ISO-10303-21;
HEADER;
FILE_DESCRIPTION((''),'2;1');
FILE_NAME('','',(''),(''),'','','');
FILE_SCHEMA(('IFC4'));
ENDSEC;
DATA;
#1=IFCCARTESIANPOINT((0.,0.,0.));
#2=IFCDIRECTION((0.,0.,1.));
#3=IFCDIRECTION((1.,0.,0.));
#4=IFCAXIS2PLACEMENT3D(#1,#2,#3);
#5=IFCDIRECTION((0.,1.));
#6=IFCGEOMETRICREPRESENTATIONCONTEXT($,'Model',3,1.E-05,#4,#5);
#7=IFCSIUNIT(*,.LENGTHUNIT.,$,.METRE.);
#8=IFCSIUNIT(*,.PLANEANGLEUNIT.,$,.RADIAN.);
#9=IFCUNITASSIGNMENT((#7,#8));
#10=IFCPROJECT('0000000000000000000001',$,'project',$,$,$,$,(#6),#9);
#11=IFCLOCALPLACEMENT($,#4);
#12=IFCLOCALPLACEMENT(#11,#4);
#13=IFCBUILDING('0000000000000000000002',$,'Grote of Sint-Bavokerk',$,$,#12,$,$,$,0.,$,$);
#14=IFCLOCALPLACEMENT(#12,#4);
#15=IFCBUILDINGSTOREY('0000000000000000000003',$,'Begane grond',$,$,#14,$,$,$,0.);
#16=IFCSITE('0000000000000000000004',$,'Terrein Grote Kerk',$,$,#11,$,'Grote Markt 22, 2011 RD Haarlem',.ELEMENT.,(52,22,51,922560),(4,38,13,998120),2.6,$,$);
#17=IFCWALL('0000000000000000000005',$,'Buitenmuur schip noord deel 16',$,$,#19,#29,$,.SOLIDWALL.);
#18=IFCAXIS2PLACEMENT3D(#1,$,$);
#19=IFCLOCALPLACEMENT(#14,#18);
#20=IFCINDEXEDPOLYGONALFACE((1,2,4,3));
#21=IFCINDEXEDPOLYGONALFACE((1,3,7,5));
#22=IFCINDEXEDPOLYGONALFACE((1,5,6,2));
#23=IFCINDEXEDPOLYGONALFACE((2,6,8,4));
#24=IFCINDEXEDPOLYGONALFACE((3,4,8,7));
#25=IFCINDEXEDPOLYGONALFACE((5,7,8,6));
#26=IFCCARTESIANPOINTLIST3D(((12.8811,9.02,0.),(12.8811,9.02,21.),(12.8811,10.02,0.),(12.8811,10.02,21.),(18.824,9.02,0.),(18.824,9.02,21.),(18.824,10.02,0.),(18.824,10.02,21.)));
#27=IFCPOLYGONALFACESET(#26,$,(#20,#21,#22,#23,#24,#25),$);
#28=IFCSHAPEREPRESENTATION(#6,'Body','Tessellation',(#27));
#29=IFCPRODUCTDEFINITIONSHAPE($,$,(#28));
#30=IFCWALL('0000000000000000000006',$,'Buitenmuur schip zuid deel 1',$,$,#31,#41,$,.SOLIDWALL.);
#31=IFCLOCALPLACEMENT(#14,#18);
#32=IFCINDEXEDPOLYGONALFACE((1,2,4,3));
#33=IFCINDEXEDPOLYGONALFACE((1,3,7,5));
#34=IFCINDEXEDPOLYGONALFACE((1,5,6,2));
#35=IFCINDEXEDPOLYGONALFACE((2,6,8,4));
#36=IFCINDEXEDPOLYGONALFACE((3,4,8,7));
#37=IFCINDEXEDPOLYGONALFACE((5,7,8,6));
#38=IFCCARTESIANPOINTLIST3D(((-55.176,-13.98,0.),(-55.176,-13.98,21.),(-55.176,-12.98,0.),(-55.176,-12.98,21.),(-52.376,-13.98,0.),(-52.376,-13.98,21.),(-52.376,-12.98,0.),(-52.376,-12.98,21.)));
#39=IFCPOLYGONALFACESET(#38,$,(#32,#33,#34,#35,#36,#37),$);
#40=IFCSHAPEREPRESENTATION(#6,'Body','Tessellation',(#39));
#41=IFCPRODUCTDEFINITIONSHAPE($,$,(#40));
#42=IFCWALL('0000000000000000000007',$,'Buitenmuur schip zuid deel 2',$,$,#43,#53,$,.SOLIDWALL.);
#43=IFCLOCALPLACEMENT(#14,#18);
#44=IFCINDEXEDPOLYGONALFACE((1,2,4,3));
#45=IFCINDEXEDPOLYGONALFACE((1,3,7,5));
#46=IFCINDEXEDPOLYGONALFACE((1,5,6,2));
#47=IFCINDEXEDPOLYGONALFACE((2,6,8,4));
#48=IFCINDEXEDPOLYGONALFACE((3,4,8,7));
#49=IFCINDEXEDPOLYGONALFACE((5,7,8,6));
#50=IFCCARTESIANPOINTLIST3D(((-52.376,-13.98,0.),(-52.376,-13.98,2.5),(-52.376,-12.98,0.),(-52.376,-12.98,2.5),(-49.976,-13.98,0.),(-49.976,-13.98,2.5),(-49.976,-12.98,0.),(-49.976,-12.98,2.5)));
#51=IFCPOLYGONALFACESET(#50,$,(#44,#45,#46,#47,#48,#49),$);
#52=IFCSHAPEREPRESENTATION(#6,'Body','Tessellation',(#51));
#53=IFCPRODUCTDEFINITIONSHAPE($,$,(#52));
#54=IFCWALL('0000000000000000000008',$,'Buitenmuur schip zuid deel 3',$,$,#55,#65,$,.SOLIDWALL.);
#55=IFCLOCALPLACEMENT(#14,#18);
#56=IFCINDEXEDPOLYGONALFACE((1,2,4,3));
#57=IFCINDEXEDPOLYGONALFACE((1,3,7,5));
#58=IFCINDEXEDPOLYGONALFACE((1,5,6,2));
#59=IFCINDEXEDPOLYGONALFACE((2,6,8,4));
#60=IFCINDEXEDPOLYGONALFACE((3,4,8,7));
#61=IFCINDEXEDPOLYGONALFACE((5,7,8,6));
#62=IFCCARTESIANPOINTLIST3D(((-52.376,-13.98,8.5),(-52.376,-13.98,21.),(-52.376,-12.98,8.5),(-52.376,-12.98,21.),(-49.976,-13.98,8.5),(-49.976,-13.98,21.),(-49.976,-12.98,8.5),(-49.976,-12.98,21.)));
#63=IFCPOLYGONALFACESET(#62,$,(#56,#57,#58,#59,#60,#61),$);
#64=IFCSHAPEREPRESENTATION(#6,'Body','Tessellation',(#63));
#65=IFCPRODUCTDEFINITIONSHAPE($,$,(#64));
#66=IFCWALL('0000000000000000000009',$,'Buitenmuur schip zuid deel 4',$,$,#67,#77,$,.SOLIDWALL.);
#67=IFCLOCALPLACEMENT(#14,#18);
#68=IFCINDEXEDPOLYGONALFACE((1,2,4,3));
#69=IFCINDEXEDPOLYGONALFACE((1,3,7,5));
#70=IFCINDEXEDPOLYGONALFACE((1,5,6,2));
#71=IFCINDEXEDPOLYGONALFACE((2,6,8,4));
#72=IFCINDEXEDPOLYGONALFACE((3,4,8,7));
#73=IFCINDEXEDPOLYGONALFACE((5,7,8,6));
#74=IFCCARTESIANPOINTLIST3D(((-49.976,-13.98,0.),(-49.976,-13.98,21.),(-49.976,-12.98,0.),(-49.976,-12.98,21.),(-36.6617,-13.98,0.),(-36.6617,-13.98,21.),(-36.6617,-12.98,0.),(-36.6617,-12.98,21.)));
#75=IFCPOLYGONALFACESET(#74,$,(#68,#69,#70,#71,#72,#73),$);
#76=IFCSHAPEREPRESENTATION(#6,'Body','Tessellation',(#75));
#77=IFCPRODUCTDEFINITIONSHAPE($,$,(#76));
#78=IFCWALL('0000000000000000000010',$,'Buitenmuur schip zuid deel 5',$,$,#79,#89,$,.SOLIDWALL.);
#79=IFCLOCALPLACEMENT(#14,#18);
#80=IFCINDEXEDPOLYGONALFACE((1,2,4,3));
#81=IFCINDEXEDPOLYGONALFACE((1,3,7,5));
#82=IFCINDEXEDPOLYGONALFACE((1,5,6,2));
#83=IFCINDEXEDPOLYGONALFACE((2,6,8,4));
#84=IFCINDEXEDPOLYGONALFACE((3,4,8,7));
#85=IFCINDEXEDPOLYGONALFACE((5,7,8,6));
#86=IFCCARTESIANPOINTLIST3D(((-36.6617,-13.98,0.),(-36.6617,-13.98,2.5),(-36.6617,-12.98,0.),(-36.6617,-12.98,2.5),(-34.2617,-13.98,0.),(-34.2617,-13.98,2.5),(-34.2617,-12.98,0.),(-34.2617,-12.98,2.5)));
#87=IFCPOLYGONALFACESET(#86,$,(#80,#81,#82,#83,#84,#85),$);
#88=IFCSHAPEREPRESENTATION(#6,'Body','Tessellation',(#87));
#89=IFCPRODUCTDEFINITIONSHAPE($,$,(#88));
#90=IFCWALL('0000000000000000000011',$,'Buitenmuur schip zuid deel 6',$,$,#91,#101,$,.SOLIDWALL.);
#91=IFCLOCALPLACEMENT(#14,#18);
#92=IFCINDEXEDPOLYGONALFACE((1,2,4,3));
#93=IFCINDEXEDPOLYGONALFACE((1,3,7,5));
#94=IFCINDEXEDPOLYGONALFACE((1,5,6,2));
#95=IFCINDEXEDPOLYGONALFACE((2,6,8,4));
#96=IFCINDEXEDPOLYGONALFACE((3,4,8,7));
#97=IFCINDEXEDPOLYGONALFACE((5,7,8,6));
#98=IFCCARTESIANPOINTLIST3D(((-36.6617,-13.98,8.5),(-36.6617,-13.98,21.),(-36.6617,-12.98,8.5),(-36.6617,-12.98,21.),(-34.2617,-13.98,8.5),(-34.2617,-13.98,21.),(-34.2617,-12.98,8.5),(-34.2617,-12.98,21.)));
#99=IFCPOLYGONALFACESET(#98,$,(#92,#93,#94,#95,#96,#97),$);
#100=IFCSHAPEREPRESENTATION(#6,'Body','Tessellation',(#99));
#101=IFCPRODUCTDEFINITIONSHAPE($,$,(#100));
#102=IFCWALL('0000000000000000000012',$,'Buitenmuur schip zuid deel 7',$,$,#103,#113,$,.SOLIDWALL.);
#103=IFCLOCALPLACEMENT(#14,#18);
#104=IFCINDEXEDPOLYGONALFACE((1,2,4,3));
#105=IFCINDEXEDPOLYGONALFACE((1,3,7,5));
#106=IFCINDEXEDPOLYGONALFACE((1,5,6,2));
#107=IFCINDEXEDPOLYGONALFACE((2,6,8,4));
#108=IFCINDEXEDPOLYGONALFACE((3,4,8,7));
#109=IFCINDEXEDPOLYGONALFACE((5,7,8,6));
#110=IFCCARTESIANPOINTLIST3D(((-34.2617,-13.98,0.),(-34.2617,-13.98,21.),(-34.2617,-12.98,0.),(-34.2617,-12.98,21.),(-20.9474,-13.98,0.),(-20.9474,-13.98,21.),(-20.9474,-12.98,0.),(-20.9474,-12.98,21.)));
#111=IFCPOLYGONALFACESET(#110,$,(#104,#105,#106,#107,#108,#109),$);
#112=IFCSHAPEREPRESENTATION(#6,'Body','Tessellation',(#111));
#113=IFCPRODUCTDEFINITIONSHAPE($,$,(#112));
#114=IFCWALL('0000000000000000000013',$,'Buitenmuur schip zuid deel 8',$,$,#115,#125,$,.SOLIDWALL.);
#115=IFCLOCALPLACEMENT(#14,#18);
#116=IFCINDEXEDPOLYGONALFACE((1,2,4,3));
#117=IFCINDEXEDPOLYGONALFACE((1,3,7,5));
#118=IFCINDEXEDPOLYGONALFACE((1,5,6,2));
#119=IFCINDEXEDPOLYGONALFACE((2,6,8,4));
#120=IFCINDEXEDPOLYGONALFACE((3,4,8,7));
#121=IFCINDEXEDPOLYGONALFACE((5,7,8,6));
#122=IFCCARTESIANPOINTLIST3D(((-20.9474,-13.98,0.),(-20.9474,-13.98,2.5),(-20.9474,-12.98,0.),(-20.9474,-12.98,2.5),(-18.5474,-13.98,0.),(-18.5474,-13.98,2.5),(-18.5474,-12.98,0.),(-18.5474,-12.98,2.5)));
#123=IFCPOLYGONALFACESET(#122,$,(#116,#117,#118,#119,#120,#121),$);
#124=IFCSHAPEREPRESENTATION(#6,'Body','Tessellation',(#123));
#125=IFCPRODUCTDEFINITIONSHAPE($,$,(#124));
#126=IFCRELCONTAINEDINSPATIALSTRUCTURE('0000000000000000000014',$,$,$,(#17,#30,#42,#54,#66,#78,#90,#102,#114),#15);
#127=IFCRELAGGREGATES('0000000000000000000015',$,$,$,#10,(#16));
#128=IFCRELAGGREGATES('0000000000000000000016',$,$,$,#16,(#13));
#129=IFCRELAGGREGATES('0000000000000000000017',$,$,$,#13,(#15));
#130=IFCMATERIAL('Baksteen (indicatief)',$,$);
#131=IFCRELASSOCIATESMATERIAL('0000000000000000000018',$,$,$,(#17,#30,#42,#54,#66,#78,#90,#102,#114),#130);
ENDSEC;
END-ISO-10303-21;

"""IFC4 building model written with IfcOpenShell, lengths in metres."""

from ifc_helpers import new_model, si_unit, direction, frame, origin_with_axes, place, context, project, spatial, indexed_curve, outline, extrude, material, element, save


model = new_model("IFC4")

# Units and contexts
model_context = context("Model", 3, precision=1e-05, world=origin_with_axes(), true_north=direction((0.0, 1.0)))
ifc_project = project(units=[si_unit("LENGTHUNIT", "METRE"), si_unit("PLANEANGLEUNIT", "RADIAN")], contexts=[model_context])

# Site, building, storey
site_placement = place(None, origin_with_axes())
site = spatial("IfcSite", under=ifc_project, at=site_placement, Name="Terrein Grote Kerk", LongName="Grote Markt 22, 2011 RD Haarlem", CompositionType="ELEMENT", RefLatitude=(52, 22, 51, 922560), RefLongitude=(4, 38, 13, 998120), RefElevation=2.6)
building_placement = place(site_placement, origin_with_axes())
building = spatial("IfcBuilding", under=site, at=building_placement, Name="Grote of Sint-Bavokerk", ElevationOfRefHeight=0.0)
storey_placement = place(building_placement, origin_with_axes())
storey = spatial("IfcBuildingStorey", under=building, at=storey_placement, Name="Begane grond", Elevation=0.0)

# Shared definitions
ifc_material = material(Name="Baksteen (indicatief)")

# Walls
wall_1_placement = place(storey_placement, origin_with_axes())
element("IfcWall", 1, at=wall_1_placement, inside=storey, material=ifc_material, Name="Buitenmuur schip noord deel 16", PredefinedType="SOLIDWALL", context=model_context, shape_type="SweptSolid", body=[
    extrude(outline(indexed_curve([(12.8811, 9.02), (18.824, 9.02), (18.824, 10.02), (12.8811, 10.02), (12.8811, 9.02)])), origin_with_axes(), (0.0, 0.0, 1.0), 21.0),
])
wall_2_placement = place(storey_placement, origin_with_axes())
element("IfcWall", 2, at=wall_2_placement, inside=storey, material=ifc_material, Name="Buitenmuur schip zuid deel 1", PredefinedType="SOLIDWALL", context=model_context, shape_type="SweptSolid", body=[
    extrude(outline(indexed_curve([(-55.176, -13.98), (-52.376, -13.98), (-52.376, -12.98), (-55.176, -12.98), (-55.176, -13.98)])), origin_with_axes(), (0.0, 0.0, 1.0), 21.0),
])
wall_3_placement = place(storey_placement, origin_with_axes())
element("IfcWall", 3, at=wall_3_placement, inside=storey, material=ifc_material, Name="Buitenmuur schip zuid deel 2", PredefinedType="SOLIDWALL", context=model_context, shape_type="SweptSolid", body=[
    extrude(outline(indexed_curve([(-52.376, -13.98), (-49.976, -13.98), (-49.976, -12.98), (-52.376, -12.98), (-52.376, -13.98)])), origin_with_axes(), (0.0, 0.0, 1.0), 2.5),
])
wall_4_placement = place(storey_placement, origin_with_axes())
element("IfcWall", 4, at=wall_4_placement, inside=storey, material=ifc_material, Name="Buitenmuur schip zuid deel 3", PredefinedType="SOLIDWALL", context=model_context, shape_type="SweptSolid", body=[
    extrude(outline(indexed_curve([(-52.376, -13.98), (-49.976, -13.98), (-49.976, -12.98), (-52.376, -12.98), (-52.376, -13.98)])), frame((0.0, 0.0, 8.5), z_axis=(0.0, 0.0, 1.0), x_axis=(1.0, 0.0, 0.0)), (0.0, 0.0, 1.0), 12.5),
])
wall_5_placement = place(storey_placement, origin_with_axes())
element("IfcWall", 5, at=wall_5_placement, inside=storey, material=ifc_material, Name="Buitenmuur schip zuid deel 4", PredefinedType="SOLIDWALL", context=model_context, shape_type="SweptSolid", body=[
    extrude(outline(indexed_curve([(-49.976, -13.98), (-36.6617, -13.98), (-36.6617, -12.98), (-49.976, -12.98), (-49.976, -13.98)])), origin_with_axes(), (0.0, 0.0, 1.0), 21.0),
])
wall_6_placement = place(storey_placement, origin_with_axes())
element("IfcWall", 6, at=wall_6_placement, inside=storey, material=ifc_material, Name="Buitenmuur schip zuid deel 5", PredefinedType="SOLIDWALL", context=model_context, shape_type="SweptSolid", body=[
    extrude(outline(indexed_curve([(-36.6617, -13.98), (-34.2617, -13.98), (-34.2617, -12.98), (-36.6617, -12.98), (-36.6617, -13.98)])), origin_with_axes(), (0.0, 0.0, 1.0), 2.5),
])
wall_7_placement = place(storey_placement, origin_with_axes())
element("IfcWall", 7, at=wall_7_placement, inside=storey, material=ifc_material, Name="Buitenmuur schip zuid deel 6", PredefinedType="SOLIDWALL", context=model_context, shape_type="SweptSolid", body=[
    extrude(outline(indexed_curve([(-36.6617, -13.98), (-34.2617, -13.98), (-34.2617, -12.98), (-36.6617, -12.98), (-36.6617, -13.98)])), frame((0.0, 0.0, 8.5), z_axis=(0.0, 0.0, 1.0), x_axis=(1.0, 0.0, 0.0)), (0.0, 0.0, 1.0), 12.5),
])
wall_8_placement = place(storey_placement, origin_with_axes())
element("IfcWall", 8, at=wall_8_placement, inside=storey, material=ifc_material, Name="Buitenmuur schip zuid deel 7", PredefinedType="SOLIDWALL", context=model_context, shape_type="SweptSolid", body=[
    extrude(outline(indexed_curve([(-34.2617, -13.98), (-20.9474, -13.98), (-20.9474, -12.98), (-34.2617, -12.98), (-34.2617, -13.98)])), origin_with_axes(), (0.0, 0.0, 1.0), 21.0),
])
wall_9_placement = place(storey_placement, origin_with_axes())
element("IfcWall", 9, at=wall_9_placement, inside=storey, material=ifc_material, Name="Buitenmuur schip zuid deel 8", PredefinedType="SOLIDWALL", context=model_context, shape_type="SweptSolid", body=[
    extrude(outline(indexed_curve([(-20.9474, -13.98), (-18.5474, -13.98), (-18.5474, -12.98), (-20.9474, -12.98), (-20.9474, -13.98)])), origin_with_axes(), (0.0, 0.0, 1.0), 2.5),
])

save(model, "model.ifc")
